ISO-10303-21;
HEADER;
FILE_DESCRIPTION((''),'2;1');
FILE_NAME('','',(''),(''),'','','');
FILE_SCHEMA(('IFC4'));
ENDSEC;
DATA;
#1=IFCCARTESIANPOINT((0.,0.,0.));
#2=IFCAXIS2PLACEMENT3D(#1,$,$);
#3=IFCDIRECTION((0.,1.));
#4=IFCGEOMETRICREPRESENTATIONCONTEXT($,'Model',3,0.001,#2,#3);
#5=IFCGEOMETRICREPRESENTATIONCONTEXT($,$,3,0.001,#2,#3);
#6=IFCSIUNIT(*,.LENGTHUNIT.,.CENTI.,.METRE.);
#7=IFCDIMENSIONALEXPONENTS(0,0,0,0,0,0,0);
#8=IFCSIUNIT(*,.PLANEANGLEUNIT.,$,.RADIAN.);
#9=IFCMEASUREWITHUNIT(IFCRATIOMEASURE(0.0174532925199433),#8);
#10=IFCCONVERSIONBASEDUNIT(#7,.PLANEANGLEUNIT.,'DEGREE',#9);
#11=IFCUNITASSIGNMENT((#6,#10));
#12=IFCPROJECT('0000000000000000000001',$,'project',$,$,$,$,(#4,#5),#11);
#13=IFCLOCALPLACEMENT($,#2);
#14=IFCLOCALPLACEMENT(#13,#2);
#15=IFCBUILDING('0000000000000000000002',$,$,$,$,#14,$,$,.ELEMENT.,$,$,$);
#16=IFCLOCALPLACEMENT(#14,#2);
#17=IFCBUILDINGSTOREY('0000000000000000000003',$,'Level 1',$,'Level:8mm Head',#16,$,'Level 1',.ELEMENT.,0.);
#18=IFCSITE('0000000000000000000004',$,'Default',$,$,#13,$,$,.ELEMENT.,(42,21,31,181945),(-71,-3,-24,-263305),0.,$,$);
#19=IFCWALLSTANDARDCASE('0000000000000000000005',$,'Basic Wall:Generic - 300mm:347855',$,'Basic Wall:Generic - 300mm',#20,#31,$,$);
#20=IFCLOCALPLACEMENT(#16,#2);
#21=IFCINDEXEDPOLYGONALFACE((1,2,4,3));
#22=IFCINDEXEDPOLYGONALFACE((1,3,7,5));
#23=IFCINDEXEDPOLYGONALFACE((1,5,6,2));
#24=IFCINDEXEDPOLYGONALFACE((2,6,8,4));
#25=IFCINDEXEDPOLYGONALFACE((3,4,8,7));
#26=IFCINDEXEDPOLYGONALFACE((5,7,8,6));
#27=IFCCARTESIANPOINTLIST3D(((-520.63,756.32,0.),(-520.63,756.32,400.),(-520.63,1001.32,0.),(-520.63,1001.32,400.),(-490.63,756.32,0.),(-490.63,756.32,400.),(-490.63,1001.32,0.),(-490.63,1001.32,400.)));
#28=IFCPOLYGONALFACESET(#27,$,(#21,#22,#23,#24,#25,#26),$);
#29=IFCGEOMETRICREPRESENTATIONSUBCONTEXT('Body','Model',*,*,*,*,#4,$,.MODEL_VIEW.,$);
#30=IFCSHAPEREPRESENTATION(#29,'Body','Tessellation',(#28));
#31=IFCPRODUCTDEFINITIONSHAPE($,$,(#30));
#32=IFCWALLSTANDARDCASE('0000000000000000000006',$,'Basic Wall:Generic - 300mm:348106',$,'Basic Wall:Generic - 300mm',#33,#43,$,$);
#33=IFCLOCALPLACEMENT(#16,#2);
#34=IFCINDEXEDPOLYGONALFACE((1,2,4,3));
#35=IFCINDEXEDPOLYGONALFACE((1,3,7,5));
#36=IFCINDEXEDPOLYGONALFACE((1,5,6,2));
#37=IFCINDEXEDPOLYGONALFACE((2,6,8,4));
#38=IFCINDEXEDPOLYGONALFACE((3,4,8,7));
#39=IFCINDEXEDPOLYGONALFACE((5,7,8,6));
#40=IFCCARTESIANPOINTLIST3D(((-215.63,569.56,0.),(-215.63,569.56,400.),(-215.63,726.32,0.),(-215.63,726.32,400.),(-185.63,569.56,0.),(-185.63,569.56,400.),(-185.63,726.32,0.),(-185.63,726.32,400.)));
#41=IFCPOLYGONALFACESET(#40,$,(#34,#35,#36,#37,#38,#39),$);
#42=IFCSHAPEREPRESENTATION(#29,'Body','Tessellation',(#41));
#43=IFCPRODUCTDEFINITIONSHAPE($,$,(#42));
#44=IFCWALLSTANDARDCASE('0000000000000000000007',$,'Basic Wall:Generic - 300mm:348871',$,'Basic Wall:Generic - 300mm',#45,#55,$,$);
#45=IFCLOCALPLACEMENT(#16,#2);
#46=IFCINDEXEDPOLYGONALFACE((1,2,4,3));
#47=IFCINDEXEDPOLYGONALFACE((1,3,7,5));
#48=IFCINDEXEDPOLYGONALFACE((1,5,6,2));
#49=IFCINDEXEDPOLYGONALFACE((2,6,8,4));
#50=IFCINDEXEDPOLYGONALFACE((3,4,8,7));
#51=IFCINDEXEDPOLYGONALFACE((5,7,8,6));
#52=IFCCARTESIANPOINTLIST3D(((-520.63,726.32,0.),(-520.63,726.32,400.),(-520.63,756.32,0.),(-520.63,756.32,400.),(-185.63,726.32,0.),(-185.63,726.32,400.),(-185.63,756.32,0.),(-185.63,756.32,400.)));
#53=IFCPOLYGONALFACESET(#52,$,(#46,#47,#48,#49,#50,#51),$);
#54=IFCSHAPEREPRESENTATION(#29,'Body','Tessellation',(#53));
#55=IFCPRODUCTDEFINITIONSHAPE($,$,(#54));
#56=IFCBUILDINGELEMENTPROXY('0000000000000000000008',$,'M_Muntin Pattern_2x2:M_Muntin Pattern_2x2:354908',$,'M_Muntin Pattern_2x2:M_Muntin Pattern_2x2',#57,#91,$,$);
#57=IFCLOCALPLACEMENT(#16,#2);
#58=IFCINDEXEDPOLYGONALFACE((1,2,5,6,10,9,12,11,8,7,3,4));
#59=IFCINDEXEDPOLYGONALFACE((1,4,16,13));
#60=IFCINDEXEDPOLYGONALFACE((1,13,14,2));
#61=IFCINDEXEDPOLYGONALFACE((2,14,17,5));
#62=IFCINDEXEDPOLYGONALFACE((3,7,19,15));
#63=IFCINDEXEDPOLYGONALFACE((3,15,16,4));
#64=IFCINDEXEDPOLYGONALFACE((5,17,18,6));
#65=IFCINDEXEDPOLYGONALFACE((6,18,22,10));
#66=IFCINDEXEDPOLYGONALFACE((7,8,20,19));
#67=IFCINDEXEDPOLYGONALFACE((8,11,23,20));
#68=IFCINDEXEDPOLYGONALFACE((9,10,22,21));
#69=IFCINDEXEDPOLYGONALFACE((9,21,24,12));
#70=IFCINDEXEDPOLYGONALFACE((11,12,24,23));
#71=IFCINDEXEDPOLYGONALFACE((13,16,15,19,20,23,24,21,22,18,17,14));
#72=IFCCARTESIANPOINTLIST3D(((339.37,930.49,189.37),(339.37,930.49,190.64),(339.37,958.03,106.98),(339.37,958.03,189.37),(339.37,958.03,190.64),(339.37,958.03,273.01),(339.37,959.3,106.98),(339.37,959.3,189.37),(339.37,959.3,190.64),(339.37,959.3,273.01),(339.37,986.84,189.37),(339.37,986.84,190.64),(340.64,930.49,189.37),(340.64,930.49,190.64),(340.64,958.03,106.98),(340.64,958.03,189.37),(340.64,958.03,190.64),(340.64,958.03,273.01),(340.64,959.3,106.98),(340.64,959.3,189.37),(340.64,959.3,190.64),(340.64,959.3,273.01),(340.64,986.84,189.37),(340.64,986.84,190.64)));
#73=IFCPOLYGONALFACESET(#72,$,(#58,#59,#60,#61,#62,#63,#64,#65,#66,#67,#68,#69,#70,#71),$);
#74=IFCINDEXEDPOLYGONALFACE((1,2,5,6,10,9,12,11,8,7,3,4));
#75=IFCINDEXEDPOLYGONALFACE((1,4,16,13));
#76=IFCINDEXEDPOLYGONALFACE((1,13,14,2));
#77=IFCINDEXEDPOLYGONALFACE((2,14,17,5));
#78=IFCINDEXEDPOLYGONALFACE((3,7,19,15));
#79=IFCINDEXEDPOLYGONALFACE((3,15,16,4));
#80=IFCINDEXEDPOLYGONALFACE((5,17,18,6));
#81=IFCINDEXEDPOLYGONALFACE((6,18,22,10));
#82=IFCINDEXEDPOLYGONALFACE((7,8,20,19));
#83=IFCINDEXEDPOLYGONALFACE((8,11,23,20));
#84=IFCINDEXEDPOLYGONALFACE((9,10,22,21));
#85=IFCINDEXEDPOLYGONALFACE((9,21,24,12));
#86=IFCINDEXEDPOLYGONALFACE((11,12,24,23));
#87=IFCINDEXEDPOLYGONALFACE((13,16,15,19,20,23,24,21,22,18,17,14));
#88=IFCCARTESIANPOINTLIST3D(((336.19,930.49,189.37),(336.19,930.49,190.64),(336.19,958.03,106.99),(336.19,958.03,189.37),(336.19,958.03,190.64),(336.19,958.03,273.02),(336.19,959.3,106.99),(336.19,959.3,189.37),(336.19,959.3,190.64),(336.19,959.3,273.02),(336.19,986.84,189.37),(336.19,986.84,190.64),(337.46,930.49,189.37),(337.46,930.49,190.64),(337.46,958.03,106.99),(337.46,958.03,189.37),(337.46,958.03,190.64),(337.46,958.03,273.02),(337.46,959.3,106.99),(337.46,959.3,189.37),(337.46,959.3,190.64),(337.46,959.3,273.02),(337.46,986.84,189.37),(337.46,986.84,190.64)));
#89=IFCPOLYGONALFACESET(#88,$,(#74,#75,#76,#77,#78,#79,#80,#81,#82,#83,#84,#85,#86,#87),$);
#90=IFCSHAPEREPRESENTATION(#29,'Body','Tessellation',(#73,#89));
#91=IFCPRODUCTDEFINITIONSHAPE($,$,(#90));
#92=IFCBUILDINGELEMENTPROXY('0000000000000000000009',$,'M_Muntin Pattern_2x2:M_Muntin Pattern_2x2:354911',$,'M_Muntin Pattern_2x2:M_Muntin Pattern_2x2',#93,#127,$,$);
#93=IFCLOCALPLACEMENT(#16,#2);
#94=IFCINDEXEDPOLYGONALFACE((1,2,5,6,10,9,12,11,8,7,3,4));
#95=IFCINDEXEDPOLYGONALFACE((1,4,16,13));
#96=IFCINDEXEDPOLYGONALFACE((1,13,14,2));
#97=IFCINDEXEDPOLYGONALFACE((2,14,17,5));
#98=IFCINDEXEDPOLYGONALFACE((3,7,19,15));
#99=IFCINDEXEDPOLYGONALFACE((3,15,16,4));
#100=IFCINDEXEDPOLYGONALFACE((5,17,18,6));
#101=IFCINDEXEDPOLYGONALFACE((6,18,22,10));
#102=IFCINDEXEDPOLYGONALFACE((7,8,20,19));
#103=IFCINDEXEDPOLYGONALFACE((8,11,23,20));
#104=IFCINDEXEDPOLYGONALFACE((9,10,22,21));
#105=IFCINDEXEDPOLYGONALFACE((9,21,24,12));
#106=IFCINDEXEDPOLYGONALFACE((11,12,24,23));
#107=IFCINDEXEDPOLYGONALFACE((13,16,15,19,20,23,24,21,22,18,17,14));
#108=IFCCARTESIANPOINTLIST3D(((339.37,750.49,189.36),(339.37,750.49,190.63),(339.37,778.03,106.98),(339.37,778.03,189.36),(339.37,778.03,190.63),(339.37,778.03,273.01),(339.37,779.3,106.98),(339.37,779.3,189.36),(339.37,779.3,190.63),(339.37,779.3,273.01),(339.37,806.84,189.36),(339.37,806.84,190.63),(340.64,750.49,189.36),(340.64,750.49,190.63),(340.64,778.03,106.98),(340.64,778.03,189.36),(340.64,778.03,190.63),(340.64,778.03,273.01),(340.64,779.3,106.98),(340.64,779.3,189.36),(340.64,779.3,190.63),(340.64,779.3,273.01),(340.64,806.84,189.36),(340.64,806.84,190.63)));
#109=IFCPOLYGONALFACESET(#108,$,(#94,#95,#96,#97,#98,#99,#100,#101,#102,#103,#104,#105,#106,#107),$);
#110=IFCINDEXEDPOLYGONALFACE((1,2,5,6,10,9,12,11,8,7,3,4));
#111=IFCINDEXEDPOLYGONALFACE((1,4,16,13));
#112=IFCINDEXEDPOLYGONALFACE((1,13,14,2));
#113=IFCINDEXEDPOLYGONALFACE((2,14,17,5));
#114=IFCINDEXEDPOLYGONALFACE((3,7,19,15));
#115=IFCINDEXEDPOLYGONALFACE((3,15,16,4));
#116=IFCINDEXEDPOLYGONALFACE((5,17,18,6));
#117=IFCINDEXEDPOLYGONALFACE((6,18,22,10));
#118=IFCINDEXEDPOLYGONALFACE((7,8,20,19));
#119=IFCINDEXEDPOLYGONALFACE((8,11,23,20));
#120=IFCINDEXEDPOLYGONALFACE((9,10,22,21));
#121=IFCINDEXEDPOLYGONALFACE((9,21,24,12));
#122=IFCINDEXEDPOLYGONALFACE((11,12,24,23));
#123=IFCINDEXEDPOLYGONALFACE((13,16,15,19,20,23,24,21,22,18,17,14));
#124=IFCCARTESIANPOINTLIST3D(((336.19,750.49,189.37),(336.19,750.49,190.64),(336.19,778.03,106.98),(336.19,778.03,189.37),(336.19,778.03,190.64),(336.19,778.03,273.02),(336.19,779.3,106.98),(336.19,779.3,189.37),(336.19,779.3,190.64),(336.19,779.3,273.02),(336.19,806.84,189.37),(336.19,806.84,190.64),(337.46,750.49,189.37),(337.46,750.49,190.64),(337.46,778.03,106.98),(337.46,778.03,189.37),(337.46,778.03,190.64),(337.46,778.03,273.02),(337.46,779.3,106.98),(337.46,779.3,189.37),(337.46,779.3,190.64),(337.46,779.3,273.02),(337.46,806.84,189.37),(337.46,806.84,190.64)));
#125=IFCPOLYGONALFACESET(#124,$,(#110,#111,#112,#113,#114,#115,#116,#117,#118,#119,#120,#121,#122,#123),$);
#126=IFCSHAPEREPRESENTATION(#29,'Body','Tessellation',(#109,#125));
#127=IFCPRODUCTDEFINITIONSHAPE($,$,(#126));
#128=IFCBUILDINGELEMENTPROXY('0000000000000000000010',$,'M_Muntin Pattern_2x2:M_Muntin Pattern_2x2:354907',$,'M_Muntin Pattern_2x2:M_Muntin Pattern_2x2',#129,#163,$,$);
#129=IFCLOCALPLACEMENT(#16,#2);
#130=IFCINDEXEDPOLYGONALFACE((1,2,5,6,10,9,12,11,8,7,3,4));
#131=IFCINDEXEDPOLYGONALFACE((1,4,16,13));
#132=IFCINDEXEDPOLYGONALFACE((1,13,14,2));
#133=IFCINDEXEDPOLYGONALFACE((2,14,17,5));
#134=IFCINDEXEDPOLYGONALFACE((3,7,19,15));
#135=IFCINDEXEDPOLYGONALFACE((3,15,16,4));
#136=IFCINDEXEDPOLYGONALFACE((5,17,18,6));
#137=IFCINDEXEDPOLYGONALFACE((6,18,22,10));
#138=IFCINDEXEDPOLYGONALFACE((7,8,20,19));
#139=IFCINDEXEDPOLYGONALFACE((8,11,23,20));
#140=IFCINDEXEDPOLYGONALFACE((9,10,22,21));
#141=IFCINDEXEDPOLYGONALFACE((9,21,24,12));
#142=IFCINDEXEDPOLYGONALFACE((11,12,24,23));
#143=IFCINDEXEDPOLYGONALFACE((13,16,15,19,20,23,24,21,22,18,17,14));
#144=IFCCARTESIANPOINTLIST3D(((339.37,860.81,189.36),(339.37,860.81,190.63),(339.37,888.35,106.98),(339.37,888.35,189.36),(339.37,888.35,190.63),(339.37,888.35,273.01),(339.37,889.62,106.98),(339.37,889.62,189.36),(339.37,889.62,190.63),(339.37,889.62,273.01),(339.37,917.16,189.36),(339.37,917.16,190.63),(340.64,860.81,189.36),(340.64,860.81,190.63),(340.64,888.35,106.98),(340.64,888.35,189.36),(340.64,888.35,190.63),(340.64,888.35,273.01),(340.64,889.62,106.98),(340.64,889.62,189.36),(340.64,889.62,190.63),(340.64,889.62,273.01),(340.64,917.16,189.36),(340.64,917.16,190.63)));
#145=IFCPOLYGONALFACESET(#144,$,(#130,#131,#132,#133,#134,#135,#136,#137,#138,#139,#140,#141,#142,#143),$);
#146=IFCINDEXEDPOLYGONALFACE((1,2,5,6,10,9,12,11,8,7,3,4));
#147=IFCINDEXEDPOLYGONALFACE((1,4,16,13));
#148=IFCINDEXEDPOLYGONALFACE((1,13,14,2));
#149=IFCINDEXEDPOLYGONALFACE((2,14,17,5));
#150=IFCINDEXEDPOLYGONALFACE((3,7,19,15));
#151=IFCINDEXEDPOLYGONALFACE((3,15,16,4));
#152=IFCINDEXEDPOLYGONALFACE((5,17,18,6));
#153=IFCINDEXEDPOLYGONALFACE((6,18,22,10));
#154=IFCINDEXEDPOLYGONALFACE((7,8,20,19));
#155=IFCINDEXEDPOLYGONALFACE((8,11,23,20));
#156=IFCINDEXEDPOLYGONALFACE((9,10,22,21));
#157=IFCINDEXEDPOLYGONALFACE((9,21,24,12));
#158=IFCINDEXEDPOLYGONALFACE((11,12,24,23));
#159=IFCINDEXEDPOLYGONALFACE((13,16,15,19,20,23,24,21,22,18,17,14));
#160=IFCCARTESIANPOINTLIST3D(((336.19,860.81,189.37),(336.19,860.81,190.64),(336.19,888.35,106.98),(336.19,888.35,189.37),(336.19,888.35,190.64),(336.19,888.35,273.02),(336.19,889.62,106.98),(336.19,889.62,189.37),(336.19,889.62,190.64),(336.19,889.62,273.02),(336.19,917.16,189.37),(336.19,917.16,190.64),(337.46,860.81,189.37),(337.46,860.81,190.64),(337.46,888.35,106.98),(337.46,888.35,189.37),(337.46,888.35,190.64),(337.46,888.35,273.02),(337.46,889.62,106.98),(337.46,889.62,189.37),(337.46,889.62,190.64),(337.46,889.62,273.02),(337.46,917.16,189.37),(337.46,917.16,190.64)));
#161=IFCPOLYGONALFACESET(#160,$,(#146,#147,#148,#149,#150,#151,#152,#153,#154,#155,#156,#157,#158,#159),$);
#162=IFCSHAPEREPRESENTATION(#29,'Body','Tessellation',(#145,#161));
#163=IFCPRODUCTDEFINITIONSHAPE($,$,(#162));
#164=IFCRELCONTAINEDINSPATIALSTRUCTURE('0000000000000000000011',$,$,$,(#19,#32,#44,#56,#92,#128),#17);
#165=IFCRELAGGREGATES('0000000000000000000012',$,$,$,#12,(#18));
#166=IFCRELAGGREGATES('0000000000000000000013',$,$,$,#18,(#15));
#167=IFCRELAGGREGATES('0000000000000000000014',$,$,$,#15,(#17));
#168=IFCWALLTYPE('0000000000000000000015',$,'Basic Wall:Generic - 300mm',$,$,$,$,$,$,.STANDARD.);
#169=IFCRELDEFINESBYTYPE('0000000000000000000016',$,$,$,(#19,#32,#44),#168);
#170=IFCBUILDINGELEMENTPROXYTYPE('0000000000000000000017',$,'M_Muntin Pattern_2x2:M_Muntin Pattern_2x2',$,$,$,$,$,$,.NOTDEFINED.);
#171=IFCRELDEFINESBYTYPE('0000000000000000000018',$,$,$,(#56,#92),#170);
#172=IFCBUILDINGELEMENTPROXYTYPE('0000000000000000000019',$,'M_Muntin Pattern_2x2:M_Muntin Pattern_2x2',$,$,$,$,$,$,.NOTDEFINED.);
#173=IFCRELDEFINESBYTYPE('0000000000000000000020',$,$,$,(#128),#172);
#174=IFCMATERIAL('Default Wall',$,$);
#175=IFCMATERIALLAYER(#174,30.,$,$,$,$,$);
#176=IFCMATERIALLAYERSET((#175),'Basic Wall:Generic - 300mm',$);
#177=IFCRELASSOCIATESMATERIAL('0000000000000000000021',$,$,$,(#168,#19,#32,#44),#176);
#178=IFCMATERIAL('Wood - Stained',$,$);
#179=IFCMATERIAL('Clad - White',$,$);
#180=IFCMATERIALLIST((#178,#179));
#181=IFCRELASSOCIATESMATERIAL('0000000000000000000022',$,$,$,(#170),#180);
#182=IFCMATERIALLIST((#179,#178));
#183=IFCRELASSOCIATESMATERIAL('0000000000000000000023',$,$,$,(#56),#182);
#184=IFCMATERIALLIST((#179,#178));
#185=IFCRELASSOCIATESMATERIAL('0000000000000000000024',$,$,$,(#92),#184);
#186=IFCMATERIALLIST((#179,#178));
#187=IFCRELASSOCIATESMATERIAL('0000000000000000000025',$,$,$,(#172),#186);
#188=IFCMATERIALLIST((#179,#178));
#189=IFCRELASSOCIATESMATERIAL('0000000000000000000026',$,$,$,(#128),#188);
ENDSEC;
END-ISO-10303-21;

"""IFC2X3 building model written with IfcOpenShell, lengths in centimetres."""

from ifc_helpers import new_model, entity, si_unit, converted_unit, direction, frame, frame_2d, origin, place, context, subcontext, project, spatial, polyline, rectangle, outline, extrude, source, transform, mapped, material, material_list, layer, layer_set, layer_usage, type_object, type_shapes, element, save


model = new_model("IFC2X3")

# Units and contexts
model_context = context("Model", 3, precision=0.001, world=origin(), true_north=direction((0.0, 1.0)))
context_of_model = context(None, 3, precision=0.001, world=origin(), true_north=direction((0.0, 1.0)))
body_context = subcontext(model_context, "Body", "Model", "MODEL_VIEW")
ifc_project = project(units=[si_unit("LENGTHUNIT", "METRE", prefix="CENTI"), converted_unit("PLANEANGLEUNIT", "DEGREE", entity("IfcRatioMeasure", 0.0174532925199433), si_unit("PLANEANGLEUNIT", "RADIAN"), dimensions=[0, 0, 0, 0, 0, 0, 0])], contexts=[model_context, context_of_model])

# Site, building, storey
site_placement = place(None, origin())
site = spatial("IfcSite", under=ifc_project, at=site_placement, Name="Default", CompositionType="ELEMENT", RefLatitude=(42, 21, 31, 181945), RefLongitude=(-71, -3, -24, -263305), RefElevation=0.0)
building_placement = place(site_placement, origin())
building = spatial("IfcBuilding", under=site, at=building_placement, CompositionType="ELEMENT")
storey_placement = place(building_placement, origin())
storey = spatial("IfcBuildingStorey", under=building, at=storey_placement, Name="Level 1", ObjectType="Level:8mm Head", LongName="Level 1", CompositionType="ELEMENT", Elevation=0.0)

# Shared definitions
ifc_material_1 = material(Name="Default Wall")
ifc_layer_1 = layer(ifc_material_1, 30.0)
ifc_layer_set_1 = layer_set([ifc_layer_1], Name="Basic Wall:Generic - 300mm")
wall_type = type_object("IfcWallType", Name="Basic Wall:Generic - 300mm", PredefinedType="STANDARD", material=ifc_layer_set_1)
ifc_material_2 = material(Name="Wood - Stained")
ifc_material_3 = material(Name="Clad - White")

# Walls
ifc_layer_usage_1 = layer_usage(ifc_layer_set_1, "AXIS2", "NEGATIVE", 15.0)
wall_1_placement = place(storey_placement, frame((-505.63, 1001.32, 0.0), z_axis=(0.0, 0.0, 1.0), x_axis=(0.0, -1.0, 0.0)))
element("IfcWallStandardCase", 1, at=wall_1_placement, inside=storey, type_object=wall_type, material=ifc_layer_usage_1, Name="Basic Wall:Generic - 300mm:347855", ObjectType="Basic Wall:Generic - 300mm", context=body_context, shape_type="SweptSolid", body=[
    extrude(rectangle(XDim=245.0, YDim=30.0, at=frame_2d((122.5, 0.0), x_axis=(-1.0, 0.0))), origin(), (0.0, 0.0, 1.0), 400.0),
])
ifc_layer_usage_2 = layer_usage(ifc_layer_set_1, "AXIS2", "NEGATIVE", 15.0)
wall_2_placement = place(storey_placement, frame((-200.63, 726.32, 0.0), z_axis=(0.0, 0.0, 1.0), x_axis=(0.0, -1.0, 0.0)))
element("IfcWallStandardCase", 2, at=wall_2_placement, inside=storey, type_object=wall_type, material=ifc_layer_usage_2, Name="Basic Wall:Generic - 300mm:348106", ObjectType="Basic Wall:Generic - 300mm", context=body_context, shape_type="SweptSolid", body=[
    extrude(rectangle(XDim=156.77, YDim=30.0, at=frame_2d((78.38, 0.0), x_axis=(-1.0, 0.0))), origin(), (0.0, 0.0, 1.0), 400.0),
])
ifc_layer_usage_3 = layer_usage(ifc_layer_set_1, "AXIS2", "NEGATIVE", 15.0)
wall_3_placement = place(storey_placement, frame((-520.63, 741.32, 0.0)))
element("IfcWallStandardCase", 3, at=wall_3_placement, inside=storey, type_object=wall_type, material=ifc_layer_usage_3, Name="Basic Wall:Generic - 300mm:348871", ObjectType="Basic Wall:Generic - 300mm", context=body_context, shape_type="SweptSolid", body=[
    extrude(rectangle(XDim=335.0, YDim=30.0, at=frame_2d((167.5, 0.0), x_axis=(-1.0, 0.0))), origin(), (0.0, 0.0, 1.0), 400.0),
])

# Building element proxies
ifc_material_list_1 = material_list([ifc_material_3, ifc_material_2])
ifc_material_list_2 = material_list([ifc_material_2, ifc_material_3])
building_element_proxy_type_1 = type_object("IfcBuildingElementProxyType", Name="M_Muntin Pattern_2x2:M_Muntin Pattern_2x2", PredefinedType="NOTDEFINED", material=ifc_material_list_2)
shared_shape_1 = source(origin(), body_context, "Body", "SweptSolid", [
    extrude(outline(polyline([(0.64, -0.64), (83.01, -0.64), (83.01, 0.63), (0.64, 0.63), (0.64, 28.17), (-0.63, 28.17), (-0.63, 0.63), (-83.02, 0.63), (-83.02, -0.64), (-0.63, -0.64), (-0.63, -28.17), (0.64, -28.17), (0.64, -0.64)])), frame((0.0, 0.95, 83.01), z_axis=(0.0, 1.0, 0.0), x_axis=(0.0, 0.0, 1.0)), (0.0, 0.0, 1.0), 1.27),
    extrude(outline(polyline([(0.64, -0.64), (83.02, -0.64), (83.02, 0.63), (0.64, 0.63), (0.64, 28.17), (-0.63, 28.17), (-0.63, 0.63), (-83.02, 0.63), (-83.02, -0.64), (-0.63, -0.64), (-0.63, -28.17), (0.64, -28.17), (0.64, -0.64)])), frame((0.0, -2.22, 83.02), z_axis=(0.0, 1.0, 0.0), x_axis=(0.0, 0.0, 1.0)), (0.0, 0.0, 1.0), 1.27),
])
type_shapes(building_element_proxy_type_1, [shared_shape_1])
proxy_1_placement = place(storey_placement, frame((338.41, 958.67, 106.99), z_axis=(0.0, 0.0, 1.0), x_axis=(0.0, -1.0, 0.0)))
element("IfcBuildingElementProxy", 4, at=proxy_1_placement, inside=storey, type_object=building_element_proxy_type_1, material=ifc_material_list_1, Name="M_Muntin Pattern_2x2:M_Muntin Pattern_2x2:354908", ObjectType="M_Muntin Pattern_2x2:M_Muntin Pattern_2x2", context=body_context, shape_type="MappedRepresentation", body=[
    mapped(shared_shape_1, transform((0.0, 0.0, 0.0), scale=1.0)),
])
ifc_material_list_3 = material_list([ifc_material_3, ifc_material_2])
proxy_2_placement = place(storey_placement, frame((338.41, 778.67, 106.98), z_axis=(0.0, 0.0, 1.0), x_axis=(0.0, -1.0, 0.0)))
element("IfcBuildingElementProxy", 5, at=proxy_2_placement, inside=storey, type_object=building_element_proxy_type_1, material=ifc_material_list_3, Name="M_Muntin Pattern_2x2:M_Muntin Pattern_2x2:354911", ObjectType="M_Muntin Pattern_2x2:M_Muntin Pattern_2x2", context=body_context, shape_type="MappedRepresentation", body=[
    mapped(shared_shape_1, transform((0.0, 0.0, 0.0), scale=1.0)),
])
ifc_material_list_4 = material_list([ifc_material_3, ifc_material_2])
ifc_material_list_5 = material_list([ifc_material_3, ifc_material_2])
building_element_proxy_type_2 = type_object("IfcBuildingElementProxyType", Name="M_Muntin Pattern_2x2:M_Muntin Pattern_2x2", PredefinedType="NOTDEFINED", material=ifc_material_list_5)
shared_shape_2 = source(origin(), body_context, "Body", "SweptSolid", [
    extrude(outline(polyline([(0.64, -0.64), (83.01, -0.64), (83.01, 0.63), (0.64, 0.63), (0.64, 28.17), (-0.63, 28.17), (-0.63, 0.63), (-83.02, 0.63), (-83.02, -0.64), (-0.63, -0.64), (-0.63, -28.17), (0.64, -28.17), (0.64, -0.64)])), frame((0.0, -2.22, 83.01), z_axis=(0.0, 1.0, 0.0), x_axis=(0.0, 0.0, 1.0)), (0.0, 0.0, 1.0), 1.27),
    extrude(outline(polyline([(0.64, -0.64), (83.02, -0.64), (83.02, 0.63), (0.64, 0.63), (0.64, 28.17), (-0.63, 28.17), (-0.63, 0.63), (-83.02, 0.63), (-83.02, -0.64), (-0.63, -0.64), (-0.63, -28.17), (0.64, -28.17), (0.64, -0.64)])), frame((0.0, 0.95, 83.02), z_axis=(0.0, 1.0, 0.0), x_axis=(0.0, 0.0, 1.0)), (0.0, 0.0, 1.0), 1.27),
])
type_shapes(building_element_proxy_type_2, [shared_shape_2])
proxy_3_placement = place(storey_placement, frame((338.41, 888.98, 106.98), z_axis=(0.0, 0.0, 1.0), x_axis=(0.0, 1.0, 0.0)))
element("IfcBuildingElementProxy", 6, at=proxy_3_placement, inside=storey, type_object=building_element_proxy_type_2, material=ifc_material_list_4, Name="M_Muntin Pattern_2x2:M_Muntin Pattern_2x2:354907", ObjectType="M_Muntin Pattern_2x2:M_Muntin Pattern_2x2", context=body_context, shape_type="MappedRepresentation", body=[
    mapped(shared_shape_2, transform((0.0, 0.0, 0.0), scale=1.0)),
])

save(model, "model.ifc")
